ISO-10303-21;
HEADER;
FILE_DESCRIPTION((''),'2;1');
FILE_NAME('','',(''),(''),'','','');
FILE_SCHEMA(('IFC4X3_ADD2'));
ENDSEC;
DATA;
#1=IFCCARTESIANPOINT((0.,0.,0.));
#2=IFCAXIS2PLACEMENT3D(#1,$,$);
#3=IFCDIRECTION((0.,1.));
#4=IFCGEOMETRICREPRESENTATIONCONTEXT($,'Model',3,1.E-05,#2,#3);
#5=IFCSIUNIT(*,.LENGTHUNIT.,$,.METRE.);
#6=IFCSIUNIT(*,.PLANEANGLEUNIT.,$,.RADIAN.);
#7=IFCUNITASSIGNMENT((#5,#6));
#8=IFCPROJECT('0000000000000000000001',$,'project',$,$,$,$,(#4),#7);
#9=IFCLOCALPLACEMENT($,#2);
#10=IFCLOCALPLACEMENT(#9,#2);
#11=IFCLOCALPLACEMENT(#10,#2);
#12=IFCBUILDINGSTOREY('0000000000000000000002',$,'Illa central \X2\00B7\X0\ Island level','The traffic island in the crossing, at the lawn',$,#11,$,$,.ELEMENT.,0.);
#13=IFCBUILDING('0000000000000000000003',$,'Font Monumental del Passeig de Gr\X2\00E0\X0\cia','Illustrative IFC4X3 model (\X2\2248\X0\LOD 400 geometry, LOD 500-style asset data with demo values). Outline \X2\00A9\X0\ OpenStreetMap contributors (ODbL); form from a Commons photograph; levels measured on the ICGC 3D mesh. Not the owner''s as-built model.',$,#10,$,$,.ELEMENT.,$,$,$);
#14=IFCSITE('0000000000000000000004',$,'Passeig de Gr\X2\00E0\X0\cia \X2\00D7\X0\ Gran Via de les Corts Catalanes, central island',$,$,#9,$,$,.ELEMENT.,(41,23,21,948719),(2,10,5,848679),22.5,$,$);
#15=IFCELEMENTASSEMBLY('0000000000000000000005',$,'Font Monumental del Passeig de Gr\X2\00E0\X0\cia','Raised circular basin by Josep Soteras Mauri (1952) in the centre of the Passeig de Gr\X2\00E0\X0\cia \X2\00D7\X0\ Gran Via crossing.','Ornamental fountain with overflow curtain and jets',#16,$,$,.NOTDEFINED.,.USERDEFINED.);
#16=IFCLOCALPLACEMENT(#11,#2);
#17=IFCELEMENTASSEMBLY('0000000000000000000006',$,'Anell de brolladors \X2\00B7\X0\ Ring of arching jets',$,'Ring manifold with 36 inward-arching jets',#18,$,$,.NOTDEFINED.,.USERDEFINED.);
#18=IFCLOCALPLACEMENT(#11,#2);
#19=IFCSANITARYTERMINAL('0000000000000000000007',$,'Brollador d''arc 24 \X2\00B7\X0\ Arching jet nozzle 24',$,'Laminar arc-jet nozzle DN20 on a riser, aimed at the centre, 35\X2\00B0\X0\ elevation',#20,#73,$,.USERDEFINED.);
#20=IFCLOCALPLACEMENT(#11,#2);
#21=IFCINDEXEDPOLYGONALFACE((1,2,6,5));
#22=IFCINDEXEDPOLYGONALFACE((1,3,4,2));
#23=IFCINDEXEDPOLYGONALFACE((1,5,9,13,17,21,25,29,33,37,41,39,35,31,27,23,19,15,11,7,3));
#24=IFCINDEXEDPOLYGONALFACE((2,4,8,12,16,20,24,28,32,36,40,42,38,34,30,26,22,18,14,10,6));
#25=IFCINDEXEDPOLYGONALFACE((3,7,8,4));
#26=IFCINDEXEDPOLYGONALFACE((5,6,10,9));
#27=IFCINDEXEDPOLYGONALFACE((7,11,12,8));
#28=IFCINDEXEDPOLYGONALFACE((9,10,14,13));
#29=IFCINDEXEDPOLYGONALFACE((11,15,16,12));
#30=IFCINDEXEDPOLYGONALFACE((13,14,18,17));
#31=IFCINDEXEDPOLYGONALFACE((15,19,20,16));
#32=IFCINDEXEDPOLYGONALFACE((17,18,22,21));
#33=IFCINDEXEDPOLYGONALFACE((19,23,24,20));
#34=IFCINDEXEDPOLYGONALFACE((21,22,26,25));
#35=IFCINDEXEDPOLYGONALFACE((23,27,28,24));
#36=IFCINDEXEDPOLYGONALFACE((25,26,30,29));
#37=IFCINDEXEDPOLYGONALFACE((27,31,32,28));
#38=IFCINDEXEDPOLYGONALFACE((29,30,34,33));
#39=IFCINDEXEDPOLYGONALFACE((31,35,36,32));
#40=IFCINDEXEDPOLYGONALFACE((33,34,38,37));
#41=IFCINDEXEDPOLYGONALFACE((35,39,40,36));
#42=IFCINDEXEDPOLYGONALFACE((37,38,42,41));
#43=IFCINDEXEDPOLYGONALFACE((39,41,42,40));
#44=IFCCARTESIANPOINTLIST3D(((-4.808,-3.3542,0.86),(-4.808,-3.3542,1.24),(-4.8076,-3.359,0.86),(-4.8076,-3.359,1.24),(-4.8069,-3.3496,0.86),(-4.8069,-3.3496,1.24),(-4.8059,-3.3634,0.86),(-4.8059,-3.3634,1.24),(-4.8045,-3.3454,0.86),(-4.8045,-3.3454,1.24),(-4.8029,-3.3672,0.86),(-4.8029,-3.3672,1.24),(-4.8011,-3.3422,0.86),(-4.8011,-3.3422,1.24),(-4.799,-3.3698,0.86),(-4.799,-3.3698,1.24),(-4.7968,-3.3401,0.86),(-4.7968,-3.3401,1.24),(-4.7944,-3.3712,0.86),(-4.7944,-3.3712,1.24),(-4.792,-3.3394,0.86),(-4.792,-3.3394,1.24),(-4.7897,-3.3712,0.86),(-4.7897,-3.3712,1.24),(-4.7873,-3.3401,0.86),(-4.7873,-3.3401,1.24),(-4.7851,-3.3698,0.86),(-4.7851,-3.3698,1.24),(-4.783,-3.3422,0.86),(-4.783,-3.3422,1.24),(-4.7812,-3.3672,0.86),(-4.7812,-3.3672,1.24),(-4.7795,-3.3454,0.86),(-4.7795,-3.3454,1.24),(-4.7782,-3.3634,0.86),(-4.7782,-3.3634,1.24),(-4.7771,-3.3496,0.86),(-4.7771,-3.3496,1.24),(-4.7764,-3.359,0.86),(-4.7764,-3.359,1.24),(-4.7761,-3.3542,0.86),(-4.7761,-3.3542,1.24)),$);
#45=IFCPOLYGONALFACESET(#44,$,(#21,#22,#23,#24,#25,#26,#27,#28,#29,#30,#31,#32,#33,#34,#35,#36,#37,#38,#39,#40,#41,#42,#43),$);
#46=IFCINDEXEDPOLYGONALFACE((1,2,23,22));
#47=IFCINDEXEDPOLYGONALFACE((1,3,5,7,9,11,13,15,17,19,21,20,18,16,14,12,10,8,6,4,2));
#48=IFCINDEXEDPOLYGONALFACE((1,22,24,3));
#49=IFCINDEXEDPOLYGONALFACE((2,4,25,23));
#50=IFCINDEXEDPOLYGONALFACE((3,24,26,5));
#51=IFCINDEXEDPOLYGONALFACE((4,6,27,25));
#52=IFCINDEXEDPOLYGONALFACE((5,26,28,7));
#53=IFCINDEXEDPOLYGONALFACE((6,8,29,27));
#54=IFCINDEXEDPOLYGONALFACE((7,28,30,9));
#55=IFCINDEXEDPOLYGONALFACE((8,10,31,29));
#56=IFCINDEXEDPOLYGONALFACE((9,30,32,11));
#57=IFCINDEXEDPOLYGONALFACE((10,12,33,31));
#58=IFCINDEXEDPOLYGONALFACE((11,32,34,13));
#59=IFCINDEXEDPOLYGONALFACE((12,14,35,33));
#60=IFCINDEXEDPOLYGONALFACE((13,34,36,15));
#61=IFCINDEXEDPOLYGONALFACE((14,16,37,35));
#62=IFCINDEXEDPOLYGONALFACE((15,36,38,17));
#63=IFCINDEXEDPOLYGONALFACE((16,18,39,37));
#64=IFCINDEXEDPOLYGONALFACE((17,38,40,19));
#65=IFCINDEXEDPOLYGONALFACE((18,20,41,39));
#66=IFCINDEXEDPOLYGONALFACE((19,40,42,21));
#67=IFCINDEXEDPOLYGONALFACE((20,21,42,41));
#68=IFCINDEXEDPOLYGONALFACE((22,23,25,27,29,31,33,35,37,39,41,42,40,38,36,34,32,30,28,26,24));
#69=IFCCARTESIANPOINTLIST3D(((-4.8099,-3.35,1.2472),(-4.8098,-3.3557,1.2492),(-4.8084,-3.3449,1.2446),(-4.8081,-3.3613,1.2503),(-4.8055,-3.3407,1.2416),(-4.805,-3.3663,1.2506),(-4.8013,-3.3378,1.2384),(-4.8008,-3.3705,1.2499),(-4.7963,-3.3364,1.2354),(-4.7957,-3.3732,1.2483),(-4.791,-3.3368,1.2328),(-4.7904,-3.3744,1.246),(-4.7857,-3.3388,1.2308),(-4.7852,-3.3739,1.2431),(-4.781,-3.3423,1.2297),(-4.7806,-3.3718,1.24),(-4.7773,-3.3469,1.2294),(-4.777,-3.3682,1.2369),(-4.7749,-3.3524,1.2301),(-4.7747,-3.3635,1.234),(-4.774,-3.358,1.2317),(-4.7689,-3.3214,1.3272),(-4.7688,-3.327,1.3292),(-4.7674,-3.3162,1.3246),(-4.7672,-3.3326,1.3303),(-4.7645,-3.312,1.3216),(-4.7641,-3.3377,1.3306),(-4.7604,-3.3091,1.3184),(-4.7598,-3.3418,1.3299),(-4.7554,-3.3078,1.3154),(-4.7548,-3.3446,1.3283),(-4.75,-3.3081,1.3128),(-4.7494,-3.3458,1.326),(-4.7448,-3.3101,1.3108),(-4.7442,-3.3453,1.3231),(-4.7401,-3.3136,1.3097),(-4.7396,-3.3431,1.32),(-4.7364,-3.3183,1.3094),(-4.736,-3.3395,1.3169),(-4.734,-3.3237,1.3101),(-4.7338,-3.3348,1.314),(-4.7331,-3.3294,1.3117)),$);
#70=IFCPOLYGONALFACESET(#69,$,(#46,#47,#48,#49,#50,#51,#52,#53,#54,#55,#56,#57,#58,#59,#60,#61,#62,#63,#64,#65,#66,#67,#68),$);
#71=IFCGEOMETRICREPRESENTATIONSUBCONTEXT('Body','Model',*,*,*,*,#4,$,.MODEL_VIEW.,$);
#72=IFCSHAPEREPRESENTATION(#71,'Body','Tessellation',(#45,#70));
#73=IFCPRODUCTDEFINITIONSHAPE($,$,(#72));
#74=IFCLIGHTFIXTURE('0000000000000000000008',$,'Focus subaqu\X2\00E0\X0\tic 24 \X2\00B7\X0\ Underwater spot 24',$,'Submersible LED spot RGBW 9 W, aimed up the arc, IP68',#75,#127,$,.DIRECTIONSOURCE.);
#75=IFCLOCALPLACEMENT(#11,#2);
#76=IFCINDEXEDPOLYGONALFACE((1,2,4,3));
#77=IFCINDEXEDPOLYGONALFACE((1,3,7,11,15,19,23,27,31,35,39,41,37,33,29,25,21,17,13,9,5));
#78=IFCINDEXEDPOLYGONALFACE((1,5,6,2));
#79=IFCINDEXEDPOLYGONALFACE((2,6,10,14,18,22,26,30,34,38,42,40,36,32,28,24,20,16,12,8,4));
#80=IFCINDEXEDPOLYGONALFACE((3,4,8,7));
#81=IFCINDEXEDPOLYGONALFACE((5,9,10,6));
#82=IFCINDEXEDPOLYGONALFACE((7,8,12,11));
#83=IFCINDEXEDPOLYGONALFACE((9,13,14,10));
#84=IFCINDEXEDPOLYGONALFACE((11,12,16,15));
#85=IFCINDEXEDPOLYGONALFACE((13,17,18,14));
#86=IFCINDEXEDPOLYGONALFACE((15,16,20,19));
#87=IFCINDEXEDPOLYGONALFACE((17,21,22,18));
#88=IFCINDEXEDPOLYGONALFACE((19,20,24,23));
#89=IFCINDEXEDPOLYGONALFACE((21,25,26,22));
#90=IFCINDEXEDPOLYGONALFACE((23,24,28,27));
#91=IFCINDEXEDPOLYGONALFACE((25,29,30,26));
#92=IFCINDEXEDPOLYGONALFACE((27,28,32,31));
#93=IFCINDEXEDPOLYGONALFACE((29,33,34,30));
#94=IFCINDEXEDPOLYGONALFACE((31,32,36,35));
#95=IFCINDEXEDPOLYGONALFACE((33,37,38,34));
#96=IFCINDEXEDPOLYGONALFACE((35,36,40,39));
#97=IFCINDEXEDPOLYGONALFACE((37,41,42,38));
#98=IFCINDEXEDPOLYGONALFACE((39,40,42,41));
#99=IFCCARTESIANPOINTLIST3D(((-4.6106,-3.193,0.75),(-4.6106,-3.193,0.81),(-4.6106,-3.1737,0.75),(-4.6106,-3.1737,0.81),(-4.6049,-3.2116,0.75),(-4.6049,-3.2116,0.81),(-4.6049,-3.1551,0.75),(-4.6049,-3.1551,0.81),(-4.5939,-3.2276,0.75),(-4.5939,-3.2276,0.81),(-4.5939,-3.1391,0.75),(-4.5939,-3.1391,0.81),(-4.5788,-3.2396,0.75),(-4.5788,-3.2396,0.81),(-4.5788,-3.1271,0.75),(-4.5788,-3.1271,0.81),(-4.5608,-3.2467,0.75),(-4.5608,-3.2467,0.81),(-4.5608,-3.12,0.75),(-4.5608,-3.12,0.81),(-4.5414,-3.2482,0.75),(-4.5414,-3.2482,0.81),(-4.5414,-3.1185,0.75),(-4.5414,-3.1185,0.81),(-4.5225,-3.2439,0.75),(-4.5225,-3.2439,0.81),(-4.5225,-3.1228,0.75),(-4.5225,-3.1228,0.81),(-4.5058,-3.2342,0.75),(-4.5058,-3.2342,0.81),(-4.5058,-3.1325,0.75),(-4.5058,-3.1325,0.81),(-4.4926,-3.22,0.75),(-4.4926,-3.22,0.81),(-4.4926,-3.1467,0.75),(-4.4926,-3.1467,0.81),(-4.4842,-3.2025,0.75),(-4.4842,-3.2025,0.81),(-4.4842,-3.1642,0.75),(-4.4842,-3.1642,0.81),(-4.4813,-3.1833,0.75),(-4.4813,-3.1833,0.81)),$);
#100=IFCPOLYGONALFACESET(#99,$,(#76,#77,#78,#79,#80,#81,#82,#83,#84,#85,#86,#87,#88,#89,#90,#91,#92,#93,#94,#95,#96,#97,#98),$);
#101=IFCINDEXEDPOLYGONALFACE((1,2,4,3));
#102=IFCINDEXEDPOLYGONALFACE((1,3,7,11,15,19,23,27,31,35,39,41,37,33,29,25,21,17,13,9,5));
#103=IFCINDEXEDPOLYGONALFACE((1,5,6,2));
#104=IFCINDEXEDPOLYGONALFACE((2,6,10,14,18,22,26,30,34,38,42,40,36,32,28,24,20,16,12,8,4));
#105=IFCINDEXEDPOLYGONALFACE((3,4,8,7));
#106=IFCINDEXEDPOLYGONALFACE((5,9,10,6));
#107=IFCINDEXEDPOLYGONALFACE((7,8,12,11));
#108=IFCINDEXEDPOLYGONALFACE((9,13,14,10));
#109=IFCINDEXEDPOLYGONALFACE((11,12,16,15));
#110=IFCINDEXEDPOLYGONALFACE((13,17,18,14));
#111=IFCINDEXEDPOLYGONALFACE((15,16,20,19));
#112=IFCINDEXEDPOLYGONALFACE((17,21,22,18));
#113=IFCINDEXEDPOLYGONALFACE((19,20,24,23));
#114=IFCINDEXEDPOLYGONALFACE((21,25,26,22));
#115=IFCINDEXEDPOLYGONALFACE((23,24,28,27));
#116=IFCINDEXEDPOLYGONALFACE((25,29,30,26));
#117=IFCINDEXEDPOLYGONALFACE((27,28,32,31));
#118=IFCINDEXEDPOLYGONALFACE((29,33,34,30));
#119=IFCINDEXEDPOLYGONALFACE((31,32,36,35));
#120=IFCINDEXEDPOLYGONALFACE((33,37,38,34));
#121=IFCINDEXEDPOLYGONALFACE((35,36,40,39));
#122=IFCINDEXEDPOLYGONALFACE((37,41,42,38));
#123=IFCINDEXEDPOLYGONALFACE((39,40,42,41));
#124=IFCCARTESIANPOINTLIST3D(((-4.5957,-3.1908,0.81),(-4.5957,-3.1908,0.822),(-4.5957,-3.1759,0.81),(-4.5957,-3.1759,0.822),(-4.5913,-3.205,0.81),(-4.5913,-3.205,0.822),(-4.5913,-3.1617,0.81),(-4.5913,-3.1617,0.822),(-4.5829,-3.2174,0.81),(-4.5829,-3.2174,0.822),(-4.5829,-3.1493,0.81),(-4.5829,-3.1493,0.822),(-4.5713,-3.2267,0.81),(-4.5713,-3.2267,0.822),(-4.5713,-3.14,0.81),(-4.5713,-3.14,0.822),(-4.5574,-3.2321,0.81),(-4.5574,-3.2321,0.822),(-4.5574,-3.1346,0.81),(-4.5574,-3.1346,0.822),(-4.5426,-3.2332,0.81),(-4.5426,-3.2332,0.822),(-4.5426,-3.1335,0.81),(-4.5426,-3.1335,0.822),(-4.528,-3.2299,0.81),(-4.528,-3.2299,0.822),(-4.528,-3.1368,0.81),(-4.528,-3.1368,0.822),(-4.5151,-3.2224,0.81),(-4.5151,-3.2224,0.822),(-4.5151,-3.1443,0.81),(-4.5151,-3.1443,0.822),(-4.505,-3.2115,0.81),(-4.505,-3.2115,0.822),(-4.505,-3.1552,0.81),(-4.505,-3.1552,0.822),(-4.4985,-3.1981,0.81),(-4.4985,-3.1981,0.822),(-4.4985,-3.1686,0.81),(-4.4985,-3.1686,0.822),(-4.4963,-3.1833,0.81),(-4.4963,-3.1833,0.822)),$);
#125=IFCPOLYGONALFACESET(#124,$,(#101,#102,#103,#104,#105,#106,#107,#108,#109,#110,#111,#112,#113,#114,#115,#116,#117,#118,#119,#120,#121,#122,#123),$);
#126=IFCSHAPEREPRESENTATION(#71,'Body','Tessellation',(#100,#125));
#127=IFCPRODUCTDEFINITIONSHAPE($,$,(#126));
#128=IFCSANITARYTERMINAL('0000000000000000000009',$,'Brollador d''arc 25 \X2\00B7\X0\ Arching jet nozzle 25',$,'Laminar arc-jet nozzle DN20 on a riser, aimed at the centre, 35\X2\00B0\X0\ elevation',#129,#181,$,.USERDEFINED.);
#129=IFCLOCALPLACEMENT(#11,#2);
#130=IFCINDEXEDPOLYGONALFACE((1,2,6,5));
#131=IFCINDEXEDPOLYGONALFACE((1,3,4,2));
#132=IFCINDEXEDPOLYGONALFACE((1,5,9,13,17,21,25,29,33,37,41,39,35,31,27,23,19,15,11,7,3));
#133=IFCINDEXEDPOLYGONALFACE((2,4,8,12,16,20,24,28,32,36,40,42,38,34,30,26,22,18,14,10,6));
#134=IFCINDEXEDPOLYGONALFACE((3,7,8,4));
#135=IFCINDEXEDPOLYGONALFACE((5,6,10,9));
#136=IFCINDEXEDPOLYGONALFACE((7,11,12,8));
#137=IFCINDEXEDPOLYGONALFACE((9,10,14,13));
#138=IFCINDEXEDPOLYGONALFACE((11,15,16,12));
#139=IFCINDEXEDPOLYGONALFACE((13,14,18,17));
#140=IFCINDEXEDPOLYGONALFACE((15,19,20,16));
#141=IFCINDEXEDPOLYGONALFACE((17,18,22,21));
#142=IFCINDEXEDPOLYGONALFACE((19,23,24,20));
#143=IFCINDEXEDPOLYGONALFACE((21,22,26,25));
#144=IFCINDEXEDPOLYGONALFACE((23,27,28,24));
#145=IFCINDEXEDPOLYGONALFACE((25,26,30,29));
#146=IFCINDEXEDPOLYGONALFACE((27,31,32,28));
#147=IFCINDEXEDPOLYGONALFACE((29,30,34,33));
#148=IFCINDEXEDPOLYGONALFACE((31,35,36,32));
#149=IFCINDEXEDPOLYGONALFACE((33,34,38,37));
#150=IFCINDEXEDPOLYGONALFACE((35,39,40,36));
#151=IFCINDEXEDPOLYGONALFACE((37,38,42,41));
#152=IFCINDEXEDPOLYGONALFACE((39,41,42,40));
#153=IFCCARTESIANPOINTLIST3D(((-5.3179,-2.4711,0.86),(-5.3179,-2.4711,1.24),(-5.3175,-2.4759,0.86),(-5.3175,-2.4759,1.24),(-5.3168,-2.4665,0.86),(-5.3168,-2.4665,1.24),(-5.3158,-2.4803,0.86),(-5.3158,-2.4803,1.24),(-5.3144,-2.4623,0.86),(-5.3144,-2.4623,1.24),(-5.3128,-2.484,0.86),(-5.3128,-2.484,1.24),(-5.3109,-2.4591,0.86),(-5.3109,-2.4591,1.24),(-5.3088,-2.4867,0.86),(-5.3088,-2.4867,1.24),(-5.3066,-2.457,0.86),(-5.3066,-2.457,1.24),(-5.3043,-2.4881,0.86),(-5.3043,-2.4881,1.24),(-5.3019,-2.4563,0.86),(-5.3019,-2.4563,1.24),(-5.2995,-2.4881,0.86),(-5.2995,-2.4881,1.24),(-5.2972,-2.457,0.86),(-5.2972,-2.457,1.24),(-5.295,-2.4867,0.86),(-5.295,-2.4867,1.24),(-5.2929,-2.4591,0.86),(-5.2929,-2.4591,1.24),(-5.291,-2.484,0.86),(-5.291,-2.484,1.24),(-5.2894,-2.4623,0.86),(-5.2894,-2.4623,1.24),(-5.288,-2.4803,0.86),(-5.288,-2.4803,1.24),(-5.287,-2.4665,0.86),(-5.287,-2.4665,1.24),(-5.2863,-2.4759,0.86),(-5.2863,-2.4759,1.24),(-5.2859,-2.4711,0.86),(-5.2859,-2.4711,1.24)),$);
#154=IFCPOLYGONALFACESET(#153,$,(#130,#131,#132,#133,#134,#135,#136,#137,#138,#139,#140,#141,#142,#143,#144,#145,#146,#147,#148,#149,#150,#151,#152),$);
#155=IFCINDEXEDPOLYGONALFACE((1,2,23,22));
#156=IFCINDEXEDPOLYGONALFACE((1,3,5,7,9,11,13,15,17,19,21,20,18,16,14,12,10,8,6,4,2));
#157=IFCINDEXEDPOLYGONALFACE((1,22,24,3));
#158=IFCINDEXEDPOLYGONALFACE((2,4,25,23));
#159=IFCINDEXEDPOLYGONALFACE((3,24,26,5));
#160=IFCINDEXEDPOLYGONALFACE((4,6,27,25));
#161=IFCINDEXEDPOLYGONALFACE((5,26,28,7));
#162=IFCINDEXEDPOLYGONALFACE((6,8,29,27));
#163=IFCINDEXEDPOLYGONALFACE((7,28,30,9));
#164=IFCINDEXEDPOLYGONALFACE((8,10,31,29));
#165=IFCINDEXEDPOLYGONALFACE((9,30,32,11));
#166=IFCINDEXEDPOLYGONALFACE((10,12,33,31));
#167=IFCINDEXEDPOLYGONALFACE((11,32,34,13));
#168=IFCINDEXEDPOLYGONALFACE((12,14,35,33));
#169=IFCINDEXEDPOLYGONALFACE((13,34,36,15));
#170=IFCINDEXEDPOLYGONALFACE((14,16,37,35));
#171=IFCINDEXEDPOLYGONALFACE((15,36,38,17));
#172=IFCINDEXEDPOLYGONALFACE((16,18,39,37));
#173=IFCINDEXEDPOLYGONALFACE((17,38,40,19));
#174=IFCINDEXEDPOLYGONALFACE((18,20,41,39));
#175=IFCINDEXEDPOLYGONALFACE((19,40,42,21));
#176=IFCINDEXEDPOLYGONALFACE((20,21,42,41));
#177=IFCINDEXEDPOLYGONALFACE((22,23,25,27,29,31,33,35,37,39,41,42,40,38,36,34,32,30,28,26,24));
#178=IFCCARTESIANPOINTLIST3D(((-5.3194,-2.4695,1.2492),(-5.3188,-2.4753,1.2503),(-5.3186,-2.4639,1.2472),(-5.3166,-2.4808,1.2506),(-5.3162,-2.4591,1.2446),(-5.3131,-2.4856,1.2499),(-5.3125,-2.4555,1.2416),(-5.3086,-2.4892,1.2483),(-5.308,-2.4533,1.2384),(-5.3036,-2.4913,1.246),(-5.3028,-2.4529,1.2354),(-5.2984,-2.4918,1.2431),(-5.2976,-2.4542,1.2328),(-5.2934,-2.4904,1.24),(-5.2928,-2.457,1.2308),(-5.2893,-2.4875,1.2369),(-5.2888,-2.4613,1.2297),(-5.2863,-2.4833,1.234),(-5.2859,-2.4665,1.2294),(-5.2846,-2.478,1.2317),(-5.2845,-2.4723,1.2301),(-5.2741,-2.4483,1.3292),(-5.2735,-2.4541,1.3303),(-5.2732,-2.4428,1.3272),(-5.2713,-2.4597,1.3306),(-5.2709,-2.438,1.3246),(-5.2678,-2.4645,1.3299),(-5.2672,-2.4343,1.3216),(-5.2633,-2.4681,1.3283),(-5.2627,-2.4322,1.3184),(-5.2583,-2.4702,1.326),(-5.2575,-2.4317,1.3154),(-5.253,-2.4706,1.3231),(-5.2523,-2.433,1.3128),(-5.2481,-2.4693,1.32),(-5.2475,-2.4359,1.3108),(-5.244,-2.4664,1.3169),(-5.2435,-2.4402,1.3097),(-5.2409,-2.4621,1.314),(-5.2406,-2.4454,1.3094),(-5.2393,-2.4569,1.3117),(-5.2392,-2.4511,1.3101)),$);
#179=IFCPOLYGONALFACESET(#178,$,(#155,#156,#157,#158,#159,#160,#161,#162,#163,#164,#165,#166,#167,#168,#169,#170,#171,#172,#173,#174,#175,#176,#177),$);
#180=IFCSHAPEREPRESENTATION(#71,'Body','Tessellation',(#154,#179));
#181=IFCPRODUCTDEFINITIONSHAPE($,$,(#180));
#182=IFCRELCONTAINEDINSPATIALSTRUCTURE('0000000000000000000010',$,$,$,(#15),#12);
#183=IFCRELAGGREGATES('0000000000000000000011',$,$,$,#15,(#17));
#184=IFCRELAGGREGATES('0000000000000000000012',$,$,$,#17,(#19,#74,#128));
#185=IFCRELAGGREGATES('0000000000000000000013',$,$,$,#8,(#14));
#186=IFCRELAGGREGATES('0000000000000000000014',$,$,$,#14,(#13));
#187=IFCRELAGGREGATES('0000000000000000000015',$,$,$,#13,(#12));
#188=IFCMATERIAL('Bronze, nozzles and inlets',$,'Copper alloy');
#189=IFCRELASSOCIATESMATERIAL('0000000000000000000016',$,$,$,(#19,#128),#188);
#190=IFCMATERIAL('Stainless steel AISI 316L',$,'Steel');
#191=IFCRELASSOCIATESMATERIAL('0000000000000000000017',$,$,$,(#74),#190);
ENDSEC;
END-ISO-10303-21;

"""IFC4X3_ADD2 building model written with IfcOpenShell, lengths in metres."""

from ifc_helpers import new_model, si_unit, direction, frame, origin, origin_2d_with_axis, place, context, subcontext, project, spatial, circle, extrude, material, element, aggregate, save


model = new_model("IFC4X3_ADD2")

# Units and contexts
model_context = context("Model", 3, precision=1e-05, world=origin(), true_north=direction((0.0, 1.0)))
body_context = subcontext(model_context, "Body", "Model", "MODEL_VIEW")
ifc_project = project(units=[si_unit("LENGTHUNIT", "METRE"), si_unit("PLANEANGLEUNIT", "RADIAN")], contexts=[model_context])

# Site, building, storey
site_placement = place(None, origin())
site = spatial("IfcSite", under=ifc_project, at=site_placement, Name="Passeig de Gràcia × Gran Via de les Corts Catalanes, central island", CompositionType="ELEMENT", RefLatitude=(41, 23, 21, 948719), RefLongitude=(2, 10, 5, 848679), RefElevation=22.5)
building_placement = place(site_placement, origin())
building = spatial("IfcBuilding", under=site, at=building_placement, Name="Font Monumental del Passeig de Gràcia", Description="Illustrative IFC4X3 model (≈LOD 400 geometry, LOD 500-style asset data with demo values). Outline © OpenStreetMap contributors (ODbL); form from a Commons photograph; levels measured on the ICGC 3D mesh. Not the owner's as-built model.", CompositionType="ELEMENT")
storey_placement = place(building_placement, origin())
storey = spatial("IfcBuildingStorey", under=building, at=storey_placement, Name="Illa central · Island level", Description="The traffic island in the crossing, at the lawn", CompositionType="ELEMENT", Elevation=0.0)

# Element assemblies, sanitary terminals, light fixture
assembly_1_placement = place(building_placement, origin())
assembly_1 = element("IfcElementAssembly", 1, at=assembly_1_placement, inside=storey, Name="Font Monumental del Passeig de Gràcia", Description="Raised circular basin by Josep Soteras Mauri (1952) in the centre of the Passeig de Gràcia × Gran Via crossing.", ObjectType="Ornamental fountain with overflow curtain and jets", AssemblyPlace="NOTDEFINED", PredefinedType="USERDEFINED")
assembly_2_placement = place(building_placement, origin())
assembly_2 = element("IfcElementAssembly", 2, at=assembly_2_placement, Name="Anell de brolladors · Ring of arching jets", ObjectType="Ring manifold with 36 inward-arching jets", AssemblyPlace="NOTDEFINED", PredefinedType="USERDEFINED")
aggregate(assembly_1, [assembly_2])
ifc_material_1 = material(Name="Stainless steel AISI 316L", Category="Steel")
ifc_material_2 = material(Name="Bronze, nozzles and inlets", Category="Copper alloy")
sanitary_terminal_1_placement = place(building_placement, origin())
sanitary_terminal_1 = element("IfcSanitaryTerminal", 3, at=sanitary_terminal_1_placement, material=ifc_material_2, Name="Brollador d'arc 24 · Arching jet nozzle 24", ObjectType="Laminar arc-jet nozzle DN20 on a riser, aimed at the centre, 35° elevation", PredefinedType="USERDEFINED", context=body_context, shape_type="SweptSolid", body=[
    extrude(circle(Radius=0.016, at=origin_2d_with_axis()), frame((-4.792, -3.3554, 0.86), z_axis=(0.0, 0.0, 1.0), x_axis=(0.0, 1.0, 0.0)), (0.0, 0.0, 1.0), 0.38),
    extrude(circle(Radius=0.02, at=origin_2d_with_axis()), frame((-4.792, -3.3554, 1.24), z_axis=(0.43415, 0.303995, 0.847998), x_axis=(0.573576, -0.819152, 0.0)), (0.0, 0.0, 1.0), 0.0943),
])
light_fixture_1_placement = place(building_placement, origin())
light_fixture_1 = element("IfcLightFixture", 4, at=light_fixture_1_placement, material=ifc_material_1, Name="Focus subaquàtic 24 · Underwater spot 24", ObjectType="Submersible LED spot RGBW 9 W, aimed up the arc, IP68", PredefinedType="DIRECTIONSOURCE", context=body_context, shape_type="SweptSolid", body=[
    extrude(circle(Radius=0.065, at=origin_2d_with_axis()), frame((-4.5463, -3.1833, 0.75)), (0.0, 0.0, 1.0), 0.06),
    extrude(circle(Radius=0.05, at=origin_2d_with_axis()), frame((-4.5463, -3.1833, 0.81)), (0.0, 0.0, 1.0), 0.012),
])
sanitary_terminal_2_placement = place(building_placement, origin())
sanitary_terminal_2 = element("IfcSanitaryTerminal", 5, at=sanitary_terminal_2_placement, material=ifc_material_2, Name="Brollador d'arc 25 · Arching jet nozzle 25", ObjectType="Laminar arc-jet nozzle DN20 on a riser, aimed at the centre, 35° elevation", PredefinedType="USERDEFINED", context=body_context, shape_type="SweptSolid", body=[
    extrude(circle(Radius=0.016, at=origin_2d_with_axis()), frame((-5.3019, -2.4723, 0.86), z_axis=(0.0, 0.0, 1.0), x_axis=(0.0, 1.0, 0.0)), (0.0, 0.0, 1.0), 0.38),
    extrude(circle(Radius=0.02, at=origin_2d_with_axis()), frame((-5.3019, -2.4723, 1.24), z_axis=(0.480342, 0.223987, 0.847998), x_axis=(0.422618, -0.906308, 0.0)), (0.0, 0.0, 1.0), 0.0943),
])
aggregate(assembly_2, [sanitary_terminal_1, light_fixture_1, sanitary_terminal_2])

save(model, "model.ifc")
